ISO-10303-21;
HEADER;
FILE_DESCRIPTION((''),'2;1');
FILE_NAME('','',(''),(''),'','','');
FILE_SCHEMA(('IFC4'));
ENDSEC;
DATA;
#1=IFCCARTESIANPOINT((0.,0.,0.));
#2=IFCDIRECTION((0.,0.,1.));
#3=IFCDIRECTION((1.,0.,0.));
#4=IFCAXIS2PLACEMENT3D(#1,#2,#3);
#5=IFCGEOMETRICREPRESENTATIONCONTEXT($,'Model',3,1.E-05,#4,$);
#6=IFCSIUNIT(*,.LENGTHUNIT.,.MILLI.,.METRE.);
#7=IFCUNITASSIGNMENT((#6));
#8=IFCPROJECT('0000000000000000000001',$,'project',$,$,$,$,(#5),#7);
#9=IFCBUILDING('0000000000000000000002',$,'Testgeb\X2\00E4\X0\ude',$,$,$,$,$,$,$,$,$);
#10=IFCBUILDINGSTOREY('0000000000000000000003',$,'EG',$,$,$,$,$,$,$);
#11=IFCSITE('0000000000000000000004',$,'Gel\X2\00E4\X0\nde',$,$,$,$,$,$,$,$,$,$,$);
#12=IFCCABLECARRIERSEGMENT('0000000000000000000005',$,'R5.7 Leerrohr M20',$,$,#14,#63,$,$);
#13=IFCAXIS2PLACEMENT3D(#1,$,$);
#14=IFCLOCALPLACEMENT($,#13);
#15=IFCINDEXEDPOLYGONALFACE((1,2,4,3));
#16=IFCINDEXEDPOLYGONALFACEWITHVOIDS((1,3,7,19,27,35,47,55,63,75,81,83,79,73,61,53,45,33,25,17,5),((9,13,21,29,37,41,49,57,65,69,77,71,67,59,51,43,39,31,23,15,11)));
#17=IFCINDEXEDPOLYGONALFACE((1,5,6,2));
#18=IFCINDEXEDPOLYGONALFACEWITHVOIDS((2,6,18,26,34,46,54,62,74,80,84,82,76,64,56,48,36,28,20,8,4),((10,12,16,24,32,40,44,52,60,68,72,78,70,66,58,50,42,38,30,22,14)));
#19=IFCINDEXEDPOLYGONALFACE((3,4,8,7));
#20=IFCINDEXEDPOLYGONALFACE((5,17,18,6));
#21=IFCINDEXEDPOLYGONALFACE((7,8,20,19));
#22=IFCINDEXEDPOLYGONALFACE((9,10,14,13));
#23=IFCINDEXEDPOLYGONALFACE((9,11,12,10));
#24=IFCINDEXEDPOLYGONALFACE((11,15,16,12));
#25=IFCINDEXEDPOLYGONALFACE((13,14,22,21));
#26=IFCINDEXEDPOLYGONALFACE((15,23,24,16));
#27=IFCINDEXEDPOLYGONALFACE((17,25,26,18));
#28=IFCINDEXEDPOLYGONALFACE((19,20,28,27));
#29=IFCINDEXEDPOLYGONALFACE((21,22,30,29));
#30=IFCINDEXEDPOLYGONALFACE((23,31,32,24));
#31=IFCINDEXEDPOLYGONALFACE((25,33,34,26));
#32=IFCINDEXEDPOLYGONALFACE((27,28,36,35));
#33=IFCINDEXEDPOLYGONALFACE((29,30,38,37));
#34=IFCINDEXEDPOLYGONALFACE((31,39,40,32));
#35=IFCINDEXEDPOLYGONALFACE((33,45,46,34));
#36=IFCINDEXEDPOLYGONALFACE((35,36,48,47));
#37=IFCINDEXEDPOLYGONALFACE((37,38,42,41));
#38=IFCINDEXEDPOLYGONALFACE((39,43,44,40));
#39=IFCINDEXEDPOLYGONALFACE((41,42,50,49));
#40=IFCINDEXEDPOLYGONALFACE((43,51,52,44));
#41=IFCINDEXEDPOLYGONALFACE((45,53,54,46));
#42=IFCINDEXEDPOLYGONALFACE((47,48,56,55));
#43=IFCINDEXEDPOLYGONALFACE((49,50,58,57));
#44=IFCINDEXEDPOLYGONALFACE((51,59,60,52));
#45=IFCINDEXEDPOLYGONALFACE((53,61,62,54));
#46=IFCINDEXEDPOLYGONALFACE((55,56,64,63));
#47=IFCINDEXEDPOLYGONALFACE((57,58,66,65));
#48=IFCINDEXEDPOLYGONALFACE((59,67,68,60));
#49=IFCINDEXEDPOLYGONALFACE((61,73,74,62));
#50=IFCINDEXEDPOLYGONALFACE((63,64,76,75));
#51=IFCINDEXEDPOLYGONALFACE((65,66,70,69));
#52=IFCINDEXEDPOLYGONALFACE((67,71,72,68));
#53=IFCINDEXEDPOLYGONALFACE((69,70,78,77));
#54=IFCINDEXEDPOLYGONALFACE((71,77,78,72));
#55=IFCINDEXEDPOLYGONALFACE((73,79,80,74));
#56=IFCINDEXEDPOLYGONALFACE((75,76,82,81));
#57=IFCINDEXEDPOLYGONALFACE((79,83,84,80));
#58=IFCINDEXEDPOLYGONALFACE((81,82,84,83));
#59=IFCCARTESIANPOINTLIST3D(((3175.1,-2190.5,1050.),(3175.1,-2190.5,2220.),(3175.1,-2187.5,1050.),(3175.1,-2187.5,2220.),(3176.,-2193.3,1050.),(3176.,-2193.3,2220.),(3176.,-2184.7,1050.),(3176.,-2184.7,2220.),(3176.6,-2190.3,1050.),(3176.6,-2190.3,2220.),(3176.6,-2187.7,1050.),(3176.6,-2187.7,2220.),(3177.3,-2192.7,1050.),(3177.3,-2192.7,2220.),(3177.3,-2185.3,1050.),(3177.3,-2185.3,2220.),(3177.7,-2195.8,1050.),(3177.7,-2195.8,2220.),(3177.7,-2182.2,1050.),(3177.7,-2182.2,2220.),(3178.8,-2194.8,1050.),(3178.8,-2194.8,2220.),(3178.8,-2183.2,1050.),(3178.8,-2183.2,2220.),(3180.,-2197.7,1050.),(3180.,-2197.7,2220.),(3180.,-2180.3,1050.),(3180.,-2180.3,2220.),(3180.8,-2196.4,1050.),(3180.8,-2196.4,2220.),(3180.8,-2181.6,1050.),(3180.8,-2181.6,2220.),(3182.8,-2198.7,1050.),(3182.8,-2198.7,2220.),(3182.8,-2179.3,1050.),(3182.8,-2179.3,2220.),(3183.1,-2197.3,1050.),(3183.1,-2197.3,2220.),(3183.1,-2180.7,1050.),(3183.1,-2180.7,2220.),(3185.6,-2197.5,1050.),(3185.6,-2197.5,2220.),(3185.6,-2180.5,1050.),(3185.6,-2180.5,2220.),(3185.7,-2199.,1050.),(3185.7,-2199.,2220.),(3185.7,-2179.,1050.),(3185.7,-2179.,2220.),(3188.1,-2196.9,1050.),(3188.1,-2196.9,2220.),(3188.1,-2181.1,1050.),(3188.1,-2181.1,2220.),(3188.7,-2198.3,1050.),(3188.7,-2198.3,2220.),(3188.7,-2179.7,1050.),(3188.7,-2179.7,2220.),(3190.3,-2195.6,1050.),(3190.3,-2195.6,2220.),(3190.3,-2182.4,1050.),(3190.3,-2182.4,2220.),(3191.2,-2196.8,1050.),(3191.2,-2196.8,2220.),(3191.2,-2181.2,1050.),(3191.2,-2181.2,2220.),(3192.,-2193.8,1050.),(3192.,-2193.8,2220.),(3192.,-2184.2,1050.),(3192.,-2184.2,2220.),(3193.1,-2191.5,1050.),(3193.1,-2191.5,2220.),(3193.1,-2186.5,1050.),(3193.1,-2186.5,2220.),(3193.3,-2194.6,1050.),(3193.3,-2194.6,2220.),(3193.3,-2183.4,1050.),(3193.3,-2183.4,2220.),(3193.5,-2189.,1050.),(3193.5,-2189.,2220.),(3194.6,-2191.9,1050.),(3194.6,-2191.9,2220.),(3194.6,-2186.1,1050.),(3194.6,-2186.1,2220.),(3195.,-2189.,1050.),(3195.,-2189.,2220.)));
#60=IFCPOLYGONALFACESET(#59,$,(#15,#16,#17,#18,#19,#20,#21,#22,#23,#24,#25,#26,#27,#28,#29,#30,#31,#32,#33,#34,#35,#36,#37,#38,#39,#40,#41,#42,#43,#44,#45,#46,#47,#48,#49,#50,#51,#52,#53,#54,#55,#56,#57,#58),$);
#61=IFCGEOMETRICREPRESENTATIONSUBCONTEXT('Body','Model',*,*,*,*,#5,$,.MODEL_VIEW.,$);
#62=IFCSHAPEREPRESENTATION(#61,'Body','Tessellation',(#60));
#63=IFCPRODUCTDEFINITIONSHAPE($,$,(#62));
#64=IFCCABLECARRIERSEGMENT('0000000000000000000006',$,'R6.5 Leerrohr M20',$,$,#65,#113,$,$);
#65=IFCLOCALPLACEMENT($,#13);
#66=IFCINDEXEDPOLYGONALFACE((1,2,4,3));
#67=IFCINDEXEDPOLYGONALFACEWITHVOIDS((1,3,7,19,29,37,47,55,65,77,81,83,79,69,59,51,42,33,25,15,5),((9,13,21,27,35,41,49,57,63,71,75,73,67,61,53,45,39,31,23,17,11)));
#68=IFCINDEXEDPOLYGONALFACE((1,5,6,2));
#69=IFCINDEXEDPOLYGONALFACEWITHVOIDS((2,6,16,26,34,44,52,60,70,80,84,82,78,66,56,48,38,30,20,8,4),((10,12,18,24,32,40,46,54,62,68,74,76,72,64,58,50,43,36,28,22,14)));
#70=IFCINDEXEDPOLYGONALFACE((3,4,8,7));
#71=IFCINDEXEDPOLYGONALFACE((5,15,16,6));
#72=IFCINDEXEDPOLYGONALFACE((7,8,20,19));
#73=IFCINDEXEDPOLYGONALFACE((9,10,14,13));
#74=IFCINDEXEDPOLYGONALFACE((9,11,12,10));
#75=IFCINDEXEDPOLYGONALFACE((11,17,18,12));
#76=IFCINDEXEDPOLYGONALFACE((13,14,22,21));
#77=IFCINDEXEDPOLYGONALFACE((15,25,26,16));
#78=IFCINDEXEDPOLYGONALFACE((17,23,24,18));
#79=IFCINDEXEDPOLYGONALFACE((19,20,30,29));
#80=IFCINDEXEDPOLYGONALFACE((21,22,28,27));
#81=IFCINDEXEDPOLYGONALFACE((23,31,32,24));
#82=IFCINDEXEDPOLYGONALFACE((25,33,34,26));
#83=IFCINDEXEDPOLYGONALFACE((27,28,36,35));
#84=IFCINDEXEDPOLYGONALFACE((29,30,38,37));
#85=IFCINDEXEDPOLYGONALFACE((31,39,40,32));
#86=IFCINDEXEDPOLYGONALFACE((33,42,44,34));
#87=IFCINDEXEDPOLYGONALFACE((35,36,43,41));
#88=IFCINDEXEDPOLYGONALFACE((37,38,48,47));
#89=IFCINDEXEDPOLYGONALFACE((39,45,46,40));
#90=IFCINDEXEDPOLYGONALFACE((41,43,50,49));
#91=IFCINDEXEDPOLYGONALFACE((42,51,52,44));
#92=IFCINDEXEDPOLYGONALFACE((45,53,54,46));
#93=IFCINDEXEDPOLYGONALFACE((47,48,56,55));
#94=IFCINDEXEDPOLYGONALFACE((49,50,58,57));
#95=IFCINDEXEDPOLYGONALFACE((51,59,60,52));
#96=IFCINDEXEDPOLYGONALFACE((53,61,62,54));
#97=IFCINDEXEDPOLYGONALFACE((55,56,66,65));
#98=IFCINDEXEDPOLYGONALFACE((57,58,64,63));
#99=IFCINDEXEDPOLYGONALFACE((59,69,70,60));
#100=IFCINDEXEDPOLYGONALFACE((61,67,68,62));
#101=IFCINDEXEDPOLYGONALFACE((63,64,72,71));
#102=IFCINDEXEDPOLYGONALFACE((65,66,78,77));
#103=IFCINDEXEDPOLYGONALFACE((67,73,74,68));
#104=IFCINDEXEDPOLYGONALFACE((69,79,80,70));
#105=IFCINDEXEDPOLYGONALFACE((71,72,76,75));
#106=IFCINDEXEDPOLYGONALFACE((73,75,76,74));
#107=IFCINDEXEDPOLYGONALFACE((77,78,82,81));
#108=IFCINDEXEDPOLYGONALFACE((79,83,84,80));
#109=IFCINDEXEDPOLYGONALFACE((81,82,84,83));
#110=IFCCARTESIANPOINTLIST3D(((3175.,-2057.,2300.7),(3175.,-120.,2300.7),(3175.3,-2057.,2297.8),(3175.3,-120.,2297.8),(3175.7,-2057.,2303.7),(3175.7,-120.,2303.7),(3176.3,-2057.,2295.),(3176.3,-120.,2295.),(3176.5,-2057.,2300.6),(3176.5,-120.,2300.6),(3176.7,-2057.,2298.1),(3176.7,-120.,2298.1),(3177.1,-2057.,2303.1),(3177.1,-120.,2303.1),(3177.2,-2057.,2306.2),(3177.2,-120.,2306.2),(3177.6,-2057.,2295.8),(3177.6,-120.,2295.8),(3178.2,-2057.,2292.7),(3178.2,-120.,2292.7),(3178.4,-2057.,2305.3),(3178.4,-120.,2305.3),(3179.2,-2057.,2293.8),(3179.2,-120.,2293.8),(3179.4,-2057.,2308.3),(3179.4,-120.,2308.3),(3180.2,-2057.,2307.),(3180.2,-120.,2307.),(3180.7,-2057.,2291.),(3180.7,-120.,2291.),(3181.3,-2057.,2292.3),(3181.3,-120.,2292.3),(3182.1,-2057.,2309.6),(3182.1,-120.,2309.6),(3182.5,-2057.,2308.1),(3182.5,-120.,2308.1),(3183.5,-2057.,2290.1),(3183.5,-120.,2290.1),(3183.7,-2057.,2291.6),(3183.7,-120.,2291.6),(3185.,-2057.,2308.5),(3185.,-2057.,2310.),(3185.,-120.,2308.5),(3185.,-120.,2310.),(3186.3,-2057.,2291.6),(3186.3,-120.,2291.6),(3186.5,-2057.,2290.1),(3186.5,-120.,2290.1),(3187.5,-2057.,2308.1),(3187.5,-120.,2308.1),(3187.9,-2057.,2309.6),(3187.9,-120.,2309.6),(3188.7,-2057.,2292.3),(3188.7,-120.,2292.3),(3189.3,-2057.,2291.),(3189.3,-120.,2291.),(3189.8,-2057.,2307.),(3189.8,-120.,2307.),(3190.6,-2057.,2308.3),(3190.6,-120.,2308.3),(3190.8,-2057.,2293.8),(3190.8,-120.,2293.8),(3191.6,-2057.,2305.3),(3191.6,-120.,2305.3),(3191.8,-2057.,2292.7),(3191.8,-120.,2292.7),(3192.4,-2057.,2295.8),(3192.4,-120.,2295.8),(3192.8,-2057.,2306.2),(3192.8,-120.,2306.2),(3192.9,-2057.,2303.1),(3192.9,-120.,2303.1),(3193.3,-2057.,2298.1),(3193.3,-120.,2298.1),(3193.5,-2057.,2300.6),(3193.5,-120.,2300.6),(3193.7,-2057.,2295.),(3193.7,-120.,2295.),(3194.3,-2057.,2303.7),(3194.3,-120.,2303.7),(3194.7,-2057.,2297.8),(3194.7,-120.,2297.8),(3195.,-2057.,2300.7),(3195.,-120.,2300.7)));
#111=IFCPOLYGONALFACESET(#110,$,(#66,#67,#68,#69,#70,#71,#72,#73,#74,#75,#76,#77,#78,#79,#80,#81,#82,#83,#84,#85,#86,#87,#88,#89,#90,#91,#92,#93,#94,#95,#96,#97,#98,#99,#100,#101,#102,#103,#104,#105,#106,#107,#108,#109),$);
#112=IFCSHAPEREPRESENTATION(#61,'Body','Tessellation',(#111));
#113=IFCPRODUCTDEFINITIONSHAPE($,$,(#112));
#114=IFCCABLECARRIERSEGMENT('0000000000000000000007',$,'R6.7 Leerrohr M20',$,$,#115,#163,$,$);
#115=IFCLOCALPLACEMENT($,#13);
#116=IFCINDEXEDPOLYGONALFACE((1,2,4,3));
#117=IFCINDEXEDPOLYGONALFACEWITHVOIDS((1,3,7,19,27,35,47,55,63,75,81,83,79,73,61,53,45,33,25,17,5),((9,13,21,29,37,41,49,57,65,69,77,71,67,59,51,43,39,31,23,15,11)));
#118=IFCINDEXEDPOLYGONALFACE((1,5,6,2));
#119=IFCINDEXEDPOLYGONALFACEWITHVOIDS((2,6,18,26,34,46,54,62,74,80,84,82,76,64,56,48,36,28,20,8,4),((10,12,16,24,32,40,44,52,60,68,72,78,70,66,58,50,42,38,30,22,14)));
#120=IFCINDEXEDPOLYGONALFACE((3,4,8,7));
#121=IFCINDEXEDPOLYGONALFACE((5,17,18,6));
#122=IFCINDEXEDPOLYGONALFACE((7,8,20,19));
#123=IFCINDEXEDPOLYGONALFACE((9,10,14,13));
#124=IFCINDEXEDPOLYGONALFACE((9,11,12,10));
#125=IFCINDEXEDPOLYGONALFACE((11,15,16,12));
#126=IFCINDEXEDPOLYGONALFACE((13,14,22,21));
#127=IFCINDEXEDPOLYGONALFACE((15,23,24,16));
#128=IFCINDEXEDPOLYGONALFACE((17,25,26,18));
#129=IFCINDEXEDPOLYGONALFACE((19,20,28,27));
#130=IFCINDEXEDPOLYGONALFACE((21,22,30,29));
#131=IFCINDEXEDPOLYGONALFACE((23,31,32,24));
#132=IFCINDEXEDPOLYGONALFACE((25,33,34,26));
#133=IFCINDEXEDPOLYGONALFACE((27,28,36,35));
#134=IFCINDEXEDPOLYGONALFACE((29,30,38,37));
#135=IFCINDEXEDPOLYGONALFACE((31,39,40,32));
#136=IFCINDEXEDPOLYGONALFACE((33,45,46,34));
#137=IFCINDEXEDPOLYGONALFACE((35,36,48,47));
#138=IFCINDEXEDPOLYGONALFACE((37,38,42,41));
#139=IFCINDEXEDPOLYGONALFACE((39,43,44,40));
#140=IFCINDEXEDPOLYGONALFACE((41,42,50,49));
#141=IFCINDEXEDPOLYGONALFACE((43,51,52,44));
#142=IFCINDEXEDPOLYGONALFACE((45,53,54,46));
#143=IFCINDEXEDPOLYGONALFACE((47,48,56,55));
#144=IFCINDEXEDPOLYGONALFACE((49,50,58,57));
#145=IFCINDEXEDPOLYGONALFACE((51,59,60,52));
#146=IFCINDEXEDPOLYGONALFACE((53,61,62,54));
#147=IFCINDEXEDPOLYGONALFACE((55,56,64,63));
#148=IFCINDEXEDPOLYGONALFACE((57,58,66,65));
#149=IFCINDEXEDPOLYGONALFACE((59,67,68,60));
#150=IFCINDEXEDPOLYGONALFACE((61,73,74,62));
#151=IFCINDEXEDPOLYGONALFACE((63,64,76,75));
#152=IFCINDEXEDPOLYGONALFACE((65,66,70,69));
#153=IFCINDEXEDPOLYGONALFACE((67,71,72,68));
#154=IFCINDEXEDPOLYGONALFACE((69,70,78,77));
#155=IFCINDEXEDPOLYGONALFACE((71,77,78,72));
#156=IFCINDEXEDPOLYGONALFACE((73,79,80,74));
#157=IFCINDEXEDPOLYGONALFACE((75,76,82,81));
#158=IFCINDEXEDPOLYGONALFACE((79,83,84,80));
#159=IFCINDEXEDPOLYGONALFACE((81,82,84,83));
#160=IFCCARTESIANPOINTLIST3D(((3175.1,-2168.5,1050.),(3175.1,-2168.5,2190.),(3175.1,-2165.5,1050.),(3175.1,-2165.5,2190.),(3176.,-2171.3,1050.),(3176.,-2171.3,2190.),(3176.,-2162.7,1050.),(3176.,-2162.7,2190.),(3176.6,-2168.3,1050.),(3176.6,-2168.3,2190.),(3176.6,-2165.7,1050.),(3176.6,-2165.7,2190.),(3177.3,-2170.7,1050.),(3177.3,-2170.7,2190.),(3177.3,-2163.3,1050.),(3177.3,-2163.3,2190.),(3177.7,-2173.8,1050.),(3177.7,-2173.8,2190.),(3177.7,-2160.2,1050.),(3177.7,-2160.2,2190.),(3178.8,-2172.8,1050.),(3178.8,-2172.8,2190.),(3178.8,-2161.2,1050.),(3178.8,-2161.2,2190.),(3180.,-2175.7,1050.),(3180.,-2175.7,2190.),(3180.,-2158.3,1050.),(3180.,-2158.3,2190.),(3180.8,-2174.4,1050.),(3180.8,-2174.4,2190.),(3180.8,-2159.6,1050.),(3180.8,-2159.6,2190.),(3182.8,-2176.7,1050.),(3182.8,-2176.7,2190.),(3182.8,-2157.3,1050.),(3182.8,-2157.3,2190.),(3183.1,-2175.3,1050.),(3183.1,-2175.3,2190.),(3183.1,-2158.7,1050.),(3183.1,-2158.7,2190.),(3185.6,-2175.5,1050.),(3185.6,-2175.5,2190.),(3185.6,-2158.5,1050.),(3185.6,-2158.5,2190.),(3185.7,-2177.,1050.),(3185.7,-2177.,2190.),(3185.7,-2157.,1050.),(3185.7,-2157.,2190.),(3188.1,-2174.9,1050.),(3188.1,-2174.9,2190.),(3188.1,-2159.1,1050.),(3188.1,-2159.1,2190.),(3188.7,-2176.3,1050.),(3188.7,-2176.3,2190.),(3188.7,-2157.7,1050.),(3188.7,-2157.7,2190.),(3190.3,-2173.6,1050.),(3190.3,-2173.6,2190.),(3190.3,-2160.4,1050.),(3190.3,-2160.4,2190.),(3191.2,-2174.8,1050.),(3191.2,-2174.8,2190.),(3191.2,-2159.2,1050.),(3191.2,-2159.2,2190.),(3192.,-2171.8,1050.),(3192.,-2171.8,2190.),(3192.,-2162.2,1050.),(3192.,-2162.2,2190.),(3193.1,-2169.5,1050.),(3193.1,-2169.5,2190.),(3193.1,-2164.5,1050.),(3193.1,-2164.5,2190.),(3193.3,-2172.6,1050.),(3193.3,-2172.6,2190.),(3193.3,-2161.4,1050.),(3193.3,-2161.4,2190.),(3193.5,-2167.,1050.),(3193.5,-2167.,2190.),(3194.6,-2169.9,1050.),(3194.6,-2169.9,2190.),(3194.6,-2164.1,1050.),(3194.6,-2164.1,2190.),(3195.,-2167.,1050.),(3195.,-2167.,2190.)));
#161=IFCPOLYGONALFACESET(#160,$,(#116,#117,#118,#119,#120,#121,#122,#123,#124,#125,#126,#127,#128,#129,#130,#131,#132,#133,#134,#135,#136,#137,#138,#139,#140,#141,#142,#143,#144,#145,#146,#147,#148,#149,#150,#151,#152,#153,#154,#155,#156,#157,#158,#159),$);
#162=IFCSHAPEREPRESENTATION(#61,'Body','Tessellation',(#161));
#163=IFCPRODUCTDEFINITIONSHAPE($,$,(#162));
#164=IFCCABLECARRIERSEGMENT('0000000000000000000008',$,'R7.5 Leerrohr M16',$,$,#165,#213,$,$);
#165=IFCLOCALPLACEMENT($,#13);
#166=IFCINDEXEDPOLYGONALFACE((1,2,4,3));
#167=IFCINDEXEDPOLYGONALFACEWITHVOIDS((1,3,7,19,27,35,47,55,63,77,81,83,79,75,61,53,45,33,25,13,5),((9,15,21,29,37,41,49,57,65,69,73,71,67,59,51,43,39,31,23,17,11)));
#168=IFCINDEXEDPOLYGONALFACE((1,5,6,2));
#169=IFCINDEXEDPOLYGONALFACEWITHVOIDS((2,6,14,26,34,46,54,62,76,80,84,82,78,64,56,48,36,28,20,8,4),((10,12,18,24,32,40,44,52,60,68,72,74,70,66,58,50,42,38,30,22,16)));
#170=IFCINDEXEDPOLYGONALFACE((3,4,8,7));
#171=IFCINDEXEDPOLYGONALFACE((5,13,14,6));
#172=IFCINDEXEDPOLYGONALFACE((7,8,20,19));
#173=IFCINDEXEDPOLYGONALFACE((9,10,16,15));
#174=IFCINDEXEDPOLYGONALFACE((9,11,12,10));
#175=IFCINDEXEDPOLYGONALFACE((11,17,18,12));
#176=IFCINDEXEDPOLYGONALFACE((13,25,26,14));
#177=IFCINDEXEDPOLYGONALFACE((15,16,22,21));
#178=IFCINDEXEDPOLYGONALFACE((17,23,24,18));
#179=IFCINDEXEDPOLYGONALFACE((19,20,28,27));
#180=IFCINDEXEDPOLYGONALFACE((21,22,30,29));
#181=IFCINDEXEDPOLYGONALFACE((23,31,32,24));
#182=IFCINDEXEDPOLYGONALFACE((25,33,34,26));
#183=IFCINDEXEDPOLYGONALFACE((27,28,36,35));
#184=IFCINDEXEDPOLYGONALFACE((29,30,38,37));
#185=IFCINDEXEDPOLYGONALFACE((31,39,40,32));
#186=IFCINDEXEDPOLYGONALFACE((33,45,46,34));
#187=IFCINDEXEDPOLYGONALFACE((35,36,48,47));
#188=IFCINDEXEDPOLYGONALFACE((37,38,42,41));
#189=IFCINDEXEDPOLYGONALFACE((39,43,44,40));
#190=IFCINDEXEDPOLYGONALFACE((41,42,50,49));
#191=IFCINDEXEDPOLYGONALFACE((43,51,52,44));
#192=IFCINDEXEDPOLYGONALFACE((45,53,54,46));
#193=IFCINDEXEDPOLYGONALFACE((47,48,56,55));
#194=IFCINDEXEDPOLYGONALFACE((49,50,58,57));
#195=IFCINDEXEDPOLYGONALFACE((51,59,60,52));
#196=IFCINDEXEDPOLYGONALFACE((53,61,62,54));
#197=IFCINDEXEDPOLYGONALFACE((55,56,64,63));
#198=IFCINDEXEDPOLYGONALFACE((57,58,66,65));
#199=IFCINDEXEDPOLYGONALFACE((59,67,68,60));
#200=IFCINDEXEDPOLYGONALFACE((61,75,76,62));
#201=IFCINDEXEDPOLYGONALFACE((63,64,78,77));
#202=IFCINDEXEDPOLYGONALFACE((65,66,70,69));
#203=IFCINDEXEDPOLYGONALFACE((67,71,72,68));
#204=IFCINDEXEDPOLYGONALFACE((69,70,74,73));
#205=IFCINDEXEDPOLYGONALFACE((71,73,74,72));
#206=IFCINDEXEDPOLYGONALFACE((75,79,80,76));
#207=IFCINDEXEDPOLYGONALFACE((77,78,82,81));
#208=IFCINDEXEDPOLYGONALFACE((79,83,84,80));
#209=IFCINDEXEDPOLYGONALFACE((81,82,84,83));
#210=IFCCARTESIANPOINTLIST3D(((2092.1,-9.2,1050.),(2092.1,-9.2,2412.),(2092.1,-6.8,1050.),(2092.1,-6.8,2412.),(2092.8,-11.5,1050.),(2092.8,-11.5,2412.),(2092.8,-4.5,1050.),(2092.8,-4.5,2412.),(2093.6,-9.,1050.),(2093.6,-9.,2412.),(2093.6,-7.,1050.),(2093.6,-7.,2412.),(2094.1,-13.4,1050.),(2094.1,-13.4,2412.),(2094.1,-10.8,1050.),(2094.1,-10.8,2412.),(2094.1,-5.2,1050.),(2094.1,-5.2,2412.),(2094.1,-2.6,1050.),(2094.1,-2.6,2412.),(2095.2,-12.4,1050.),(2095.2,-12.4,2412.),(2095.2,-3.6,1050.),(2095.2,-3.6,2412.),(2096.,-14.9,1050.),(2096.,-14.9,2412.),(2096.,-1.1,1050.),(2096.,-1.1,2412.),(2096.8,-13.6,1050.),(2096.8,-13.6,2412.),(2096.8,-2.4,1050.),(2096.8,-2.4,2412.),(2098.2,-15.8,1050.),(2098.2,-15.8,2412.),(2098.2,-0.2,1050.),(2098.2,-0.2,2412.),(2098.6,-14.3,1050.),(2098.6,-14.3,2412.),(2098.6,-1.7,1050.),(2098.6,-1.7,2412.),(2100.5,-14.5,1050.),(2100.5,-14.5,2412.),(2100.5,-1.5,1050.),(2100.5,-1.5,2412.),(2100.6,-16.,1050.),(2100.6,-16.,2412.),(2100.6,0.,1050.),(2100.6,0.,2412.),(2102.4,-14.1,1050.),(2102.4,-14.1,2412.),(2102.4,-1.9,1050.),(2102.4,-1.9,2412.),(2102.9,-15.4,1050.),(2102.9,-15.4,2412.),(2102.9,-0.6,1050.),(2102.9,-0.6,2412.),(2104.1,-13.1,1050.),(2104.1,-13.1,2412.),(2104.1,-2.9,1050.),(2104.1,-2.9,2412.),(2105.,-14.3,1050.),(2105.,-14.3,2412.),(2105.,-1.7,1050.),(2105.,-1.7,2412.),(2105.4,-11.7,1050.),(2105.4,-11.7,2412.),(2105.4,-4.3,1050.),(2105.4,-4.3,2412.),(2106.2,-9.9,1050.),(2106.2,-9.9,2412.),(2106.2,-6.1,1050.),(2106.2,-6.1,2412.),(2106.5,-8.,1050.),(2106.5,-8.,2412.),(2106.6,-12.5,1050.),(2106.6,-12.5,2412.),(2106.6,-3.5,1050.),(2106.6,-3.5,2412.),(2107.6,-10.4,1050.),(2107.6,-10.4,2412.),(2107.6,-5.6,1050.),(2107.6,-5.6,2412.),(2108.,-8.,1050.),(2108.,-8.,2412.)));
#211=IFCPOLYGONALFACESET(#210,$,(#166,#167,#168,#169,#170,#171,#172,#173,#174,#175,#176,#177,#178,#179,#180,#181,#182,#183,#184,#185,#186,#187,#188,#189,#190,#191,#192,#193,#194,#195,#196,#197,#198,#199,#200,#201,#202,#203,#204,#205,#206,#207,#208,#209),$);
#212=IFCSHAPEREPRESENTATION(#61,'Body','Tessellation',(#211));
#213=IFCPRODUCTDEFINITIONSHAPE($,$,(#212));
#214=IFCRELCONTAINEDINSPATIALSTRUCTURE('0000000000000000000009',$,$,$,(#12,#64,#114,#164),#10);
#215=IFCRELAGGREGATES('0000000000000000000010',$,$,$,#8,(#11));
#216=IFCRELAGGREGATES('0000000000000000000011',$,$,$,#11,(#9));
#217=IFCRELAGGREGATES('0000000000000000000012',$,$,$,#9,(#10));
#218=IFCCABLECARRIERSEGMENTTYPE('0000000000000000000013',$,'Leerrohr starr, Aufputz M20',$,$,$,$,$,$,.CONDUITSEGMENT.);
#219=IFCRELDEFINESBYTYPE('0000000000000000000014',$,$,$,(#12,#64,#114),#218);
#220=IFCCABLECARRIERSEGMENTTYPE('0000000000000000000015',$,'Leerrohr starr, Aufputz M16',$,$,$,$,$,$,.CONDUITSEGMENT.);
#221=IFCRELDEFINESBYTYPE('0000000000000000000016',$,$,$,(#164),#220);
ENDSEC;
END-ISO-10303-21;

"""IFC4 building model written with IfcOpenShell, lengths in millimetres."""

from ifc_helpers import new_model, si_unit, frame, origin_with_axes, place, context, subcontext, project, spatial, hollow_circle, extrude, type_object, element, save


model = new_model("IFC4")

# Units and contexts
model_context = context("Model", 3, precision=1e-05, world=origin_with_axes())
body_context = subcontext(model_context, "Body", "Model", "MODEL_VIEW")
ifc_project = project(units=[si_unit("LENGTHUNIT", "METRE", prefix="MILLI")], contexts=[model_context])

# Site, building, storey
site = spatial("IfcSite", under=ifc_project, Name="Gelände")
building = spatial("IfcBuilding", under=site, Name="Testgebäude")
storey = spatial("IfcBuildingStorey", under=building, Name="EG")

# Cable carrier segments
cable_carrier_segment_type_1 = type_object("IfcCableCarrierSegmentType", Name="Leerrohr starr, Aufputz M20", PredefinedType="CONDUITSEGMENT")
cable_carrier_segment_1_placement = place(None, frame((3185.0, -2189.0, 2220.0), z_axis=(0.0, 0.0, -1.0), x_axis=(1.0, 0.0, 0.0)))
element("IfcCableCarrierSegment", 1, at=cable_carrier_segment_1_placement, inside=storey, type_object=cable_carrier_segment_type_1, Name="R5.7 Leerrohr M20", context=body_context, shape_type="SweptSolid", body=[
    extrude(hollow_circle(Radius=10.0, WallThickness=1.5), None, (0.0, 0.0, 1.0), 1170.0),
])
cable_carrier_segment_2_placement = place(None, frame((3185.0, -120.0, 2300.0), z_axis=(0.0, -1.0, 0.0), x_axis=(0.0, 0.0, 1.0)))
element("IfcCableCarrierSegment", 2, at=cable_carrier_segment_2_placement, inside=storey, type_object=cable_carrier_segment_type_1, Name="R6.5 Leerrohr M20", context=body_context, shape_type="SweptSolid", body=[
    extrude(hollow_circle(Radius=10.0, WallThickness=1.5), None, (0.0, 0.0, 1.0), 1937.0),
])
cable_carrier_segment_3_placement = place(None, frame((3185.0, -2167.0, 2190.0), z_axis=(0.0, 0.0, -1.0), x_axis=(1.0, 0.0, 0.0)))
element("IfcCableCarrierSegment", 3, at=cable_carrier_segment_3_placement, inside=storey, type_object=cable_carrier_segment_type_1, Name="R6.7 Leerrohr M20", context=body_context, shape_type="SweptSolid", body=[
    extrude(hollow_circle(Radius=10.0, WallThickness=1.5), None, (0.0, 0.0, 1.0), 1140.0),
])

# Cable carrier segment
cable_carrier_segment_type_2 = type_object("IfcCableCarrierSegmentType", Name="Leerrohr starr, Aufputz M16", PredefinedType="CONDUITSEGMENT")
cable_carrier_segment_4_placement = place(None, frame((2100.0, -8.0, 2412.0), z_axis=(0.0, 0.0, -1.0), x_axis=(1.0, 0.0, 0.0)))
element("IfcCableCarrierSegment", 4, at=cable_carrier_segment_4_placement, inside=storey, type_object=cable_carrier_segment_type_2, Name="R7.5 Leerrohr M16", context=body_context, shape_type="SweptSolid", body=[
    extrude(hollow_circle(Radius=8.0, WallThickness=1.5), None, (0.0, 0.0, 1.0), 1362.0),
])

save(model, "model.ifc")
